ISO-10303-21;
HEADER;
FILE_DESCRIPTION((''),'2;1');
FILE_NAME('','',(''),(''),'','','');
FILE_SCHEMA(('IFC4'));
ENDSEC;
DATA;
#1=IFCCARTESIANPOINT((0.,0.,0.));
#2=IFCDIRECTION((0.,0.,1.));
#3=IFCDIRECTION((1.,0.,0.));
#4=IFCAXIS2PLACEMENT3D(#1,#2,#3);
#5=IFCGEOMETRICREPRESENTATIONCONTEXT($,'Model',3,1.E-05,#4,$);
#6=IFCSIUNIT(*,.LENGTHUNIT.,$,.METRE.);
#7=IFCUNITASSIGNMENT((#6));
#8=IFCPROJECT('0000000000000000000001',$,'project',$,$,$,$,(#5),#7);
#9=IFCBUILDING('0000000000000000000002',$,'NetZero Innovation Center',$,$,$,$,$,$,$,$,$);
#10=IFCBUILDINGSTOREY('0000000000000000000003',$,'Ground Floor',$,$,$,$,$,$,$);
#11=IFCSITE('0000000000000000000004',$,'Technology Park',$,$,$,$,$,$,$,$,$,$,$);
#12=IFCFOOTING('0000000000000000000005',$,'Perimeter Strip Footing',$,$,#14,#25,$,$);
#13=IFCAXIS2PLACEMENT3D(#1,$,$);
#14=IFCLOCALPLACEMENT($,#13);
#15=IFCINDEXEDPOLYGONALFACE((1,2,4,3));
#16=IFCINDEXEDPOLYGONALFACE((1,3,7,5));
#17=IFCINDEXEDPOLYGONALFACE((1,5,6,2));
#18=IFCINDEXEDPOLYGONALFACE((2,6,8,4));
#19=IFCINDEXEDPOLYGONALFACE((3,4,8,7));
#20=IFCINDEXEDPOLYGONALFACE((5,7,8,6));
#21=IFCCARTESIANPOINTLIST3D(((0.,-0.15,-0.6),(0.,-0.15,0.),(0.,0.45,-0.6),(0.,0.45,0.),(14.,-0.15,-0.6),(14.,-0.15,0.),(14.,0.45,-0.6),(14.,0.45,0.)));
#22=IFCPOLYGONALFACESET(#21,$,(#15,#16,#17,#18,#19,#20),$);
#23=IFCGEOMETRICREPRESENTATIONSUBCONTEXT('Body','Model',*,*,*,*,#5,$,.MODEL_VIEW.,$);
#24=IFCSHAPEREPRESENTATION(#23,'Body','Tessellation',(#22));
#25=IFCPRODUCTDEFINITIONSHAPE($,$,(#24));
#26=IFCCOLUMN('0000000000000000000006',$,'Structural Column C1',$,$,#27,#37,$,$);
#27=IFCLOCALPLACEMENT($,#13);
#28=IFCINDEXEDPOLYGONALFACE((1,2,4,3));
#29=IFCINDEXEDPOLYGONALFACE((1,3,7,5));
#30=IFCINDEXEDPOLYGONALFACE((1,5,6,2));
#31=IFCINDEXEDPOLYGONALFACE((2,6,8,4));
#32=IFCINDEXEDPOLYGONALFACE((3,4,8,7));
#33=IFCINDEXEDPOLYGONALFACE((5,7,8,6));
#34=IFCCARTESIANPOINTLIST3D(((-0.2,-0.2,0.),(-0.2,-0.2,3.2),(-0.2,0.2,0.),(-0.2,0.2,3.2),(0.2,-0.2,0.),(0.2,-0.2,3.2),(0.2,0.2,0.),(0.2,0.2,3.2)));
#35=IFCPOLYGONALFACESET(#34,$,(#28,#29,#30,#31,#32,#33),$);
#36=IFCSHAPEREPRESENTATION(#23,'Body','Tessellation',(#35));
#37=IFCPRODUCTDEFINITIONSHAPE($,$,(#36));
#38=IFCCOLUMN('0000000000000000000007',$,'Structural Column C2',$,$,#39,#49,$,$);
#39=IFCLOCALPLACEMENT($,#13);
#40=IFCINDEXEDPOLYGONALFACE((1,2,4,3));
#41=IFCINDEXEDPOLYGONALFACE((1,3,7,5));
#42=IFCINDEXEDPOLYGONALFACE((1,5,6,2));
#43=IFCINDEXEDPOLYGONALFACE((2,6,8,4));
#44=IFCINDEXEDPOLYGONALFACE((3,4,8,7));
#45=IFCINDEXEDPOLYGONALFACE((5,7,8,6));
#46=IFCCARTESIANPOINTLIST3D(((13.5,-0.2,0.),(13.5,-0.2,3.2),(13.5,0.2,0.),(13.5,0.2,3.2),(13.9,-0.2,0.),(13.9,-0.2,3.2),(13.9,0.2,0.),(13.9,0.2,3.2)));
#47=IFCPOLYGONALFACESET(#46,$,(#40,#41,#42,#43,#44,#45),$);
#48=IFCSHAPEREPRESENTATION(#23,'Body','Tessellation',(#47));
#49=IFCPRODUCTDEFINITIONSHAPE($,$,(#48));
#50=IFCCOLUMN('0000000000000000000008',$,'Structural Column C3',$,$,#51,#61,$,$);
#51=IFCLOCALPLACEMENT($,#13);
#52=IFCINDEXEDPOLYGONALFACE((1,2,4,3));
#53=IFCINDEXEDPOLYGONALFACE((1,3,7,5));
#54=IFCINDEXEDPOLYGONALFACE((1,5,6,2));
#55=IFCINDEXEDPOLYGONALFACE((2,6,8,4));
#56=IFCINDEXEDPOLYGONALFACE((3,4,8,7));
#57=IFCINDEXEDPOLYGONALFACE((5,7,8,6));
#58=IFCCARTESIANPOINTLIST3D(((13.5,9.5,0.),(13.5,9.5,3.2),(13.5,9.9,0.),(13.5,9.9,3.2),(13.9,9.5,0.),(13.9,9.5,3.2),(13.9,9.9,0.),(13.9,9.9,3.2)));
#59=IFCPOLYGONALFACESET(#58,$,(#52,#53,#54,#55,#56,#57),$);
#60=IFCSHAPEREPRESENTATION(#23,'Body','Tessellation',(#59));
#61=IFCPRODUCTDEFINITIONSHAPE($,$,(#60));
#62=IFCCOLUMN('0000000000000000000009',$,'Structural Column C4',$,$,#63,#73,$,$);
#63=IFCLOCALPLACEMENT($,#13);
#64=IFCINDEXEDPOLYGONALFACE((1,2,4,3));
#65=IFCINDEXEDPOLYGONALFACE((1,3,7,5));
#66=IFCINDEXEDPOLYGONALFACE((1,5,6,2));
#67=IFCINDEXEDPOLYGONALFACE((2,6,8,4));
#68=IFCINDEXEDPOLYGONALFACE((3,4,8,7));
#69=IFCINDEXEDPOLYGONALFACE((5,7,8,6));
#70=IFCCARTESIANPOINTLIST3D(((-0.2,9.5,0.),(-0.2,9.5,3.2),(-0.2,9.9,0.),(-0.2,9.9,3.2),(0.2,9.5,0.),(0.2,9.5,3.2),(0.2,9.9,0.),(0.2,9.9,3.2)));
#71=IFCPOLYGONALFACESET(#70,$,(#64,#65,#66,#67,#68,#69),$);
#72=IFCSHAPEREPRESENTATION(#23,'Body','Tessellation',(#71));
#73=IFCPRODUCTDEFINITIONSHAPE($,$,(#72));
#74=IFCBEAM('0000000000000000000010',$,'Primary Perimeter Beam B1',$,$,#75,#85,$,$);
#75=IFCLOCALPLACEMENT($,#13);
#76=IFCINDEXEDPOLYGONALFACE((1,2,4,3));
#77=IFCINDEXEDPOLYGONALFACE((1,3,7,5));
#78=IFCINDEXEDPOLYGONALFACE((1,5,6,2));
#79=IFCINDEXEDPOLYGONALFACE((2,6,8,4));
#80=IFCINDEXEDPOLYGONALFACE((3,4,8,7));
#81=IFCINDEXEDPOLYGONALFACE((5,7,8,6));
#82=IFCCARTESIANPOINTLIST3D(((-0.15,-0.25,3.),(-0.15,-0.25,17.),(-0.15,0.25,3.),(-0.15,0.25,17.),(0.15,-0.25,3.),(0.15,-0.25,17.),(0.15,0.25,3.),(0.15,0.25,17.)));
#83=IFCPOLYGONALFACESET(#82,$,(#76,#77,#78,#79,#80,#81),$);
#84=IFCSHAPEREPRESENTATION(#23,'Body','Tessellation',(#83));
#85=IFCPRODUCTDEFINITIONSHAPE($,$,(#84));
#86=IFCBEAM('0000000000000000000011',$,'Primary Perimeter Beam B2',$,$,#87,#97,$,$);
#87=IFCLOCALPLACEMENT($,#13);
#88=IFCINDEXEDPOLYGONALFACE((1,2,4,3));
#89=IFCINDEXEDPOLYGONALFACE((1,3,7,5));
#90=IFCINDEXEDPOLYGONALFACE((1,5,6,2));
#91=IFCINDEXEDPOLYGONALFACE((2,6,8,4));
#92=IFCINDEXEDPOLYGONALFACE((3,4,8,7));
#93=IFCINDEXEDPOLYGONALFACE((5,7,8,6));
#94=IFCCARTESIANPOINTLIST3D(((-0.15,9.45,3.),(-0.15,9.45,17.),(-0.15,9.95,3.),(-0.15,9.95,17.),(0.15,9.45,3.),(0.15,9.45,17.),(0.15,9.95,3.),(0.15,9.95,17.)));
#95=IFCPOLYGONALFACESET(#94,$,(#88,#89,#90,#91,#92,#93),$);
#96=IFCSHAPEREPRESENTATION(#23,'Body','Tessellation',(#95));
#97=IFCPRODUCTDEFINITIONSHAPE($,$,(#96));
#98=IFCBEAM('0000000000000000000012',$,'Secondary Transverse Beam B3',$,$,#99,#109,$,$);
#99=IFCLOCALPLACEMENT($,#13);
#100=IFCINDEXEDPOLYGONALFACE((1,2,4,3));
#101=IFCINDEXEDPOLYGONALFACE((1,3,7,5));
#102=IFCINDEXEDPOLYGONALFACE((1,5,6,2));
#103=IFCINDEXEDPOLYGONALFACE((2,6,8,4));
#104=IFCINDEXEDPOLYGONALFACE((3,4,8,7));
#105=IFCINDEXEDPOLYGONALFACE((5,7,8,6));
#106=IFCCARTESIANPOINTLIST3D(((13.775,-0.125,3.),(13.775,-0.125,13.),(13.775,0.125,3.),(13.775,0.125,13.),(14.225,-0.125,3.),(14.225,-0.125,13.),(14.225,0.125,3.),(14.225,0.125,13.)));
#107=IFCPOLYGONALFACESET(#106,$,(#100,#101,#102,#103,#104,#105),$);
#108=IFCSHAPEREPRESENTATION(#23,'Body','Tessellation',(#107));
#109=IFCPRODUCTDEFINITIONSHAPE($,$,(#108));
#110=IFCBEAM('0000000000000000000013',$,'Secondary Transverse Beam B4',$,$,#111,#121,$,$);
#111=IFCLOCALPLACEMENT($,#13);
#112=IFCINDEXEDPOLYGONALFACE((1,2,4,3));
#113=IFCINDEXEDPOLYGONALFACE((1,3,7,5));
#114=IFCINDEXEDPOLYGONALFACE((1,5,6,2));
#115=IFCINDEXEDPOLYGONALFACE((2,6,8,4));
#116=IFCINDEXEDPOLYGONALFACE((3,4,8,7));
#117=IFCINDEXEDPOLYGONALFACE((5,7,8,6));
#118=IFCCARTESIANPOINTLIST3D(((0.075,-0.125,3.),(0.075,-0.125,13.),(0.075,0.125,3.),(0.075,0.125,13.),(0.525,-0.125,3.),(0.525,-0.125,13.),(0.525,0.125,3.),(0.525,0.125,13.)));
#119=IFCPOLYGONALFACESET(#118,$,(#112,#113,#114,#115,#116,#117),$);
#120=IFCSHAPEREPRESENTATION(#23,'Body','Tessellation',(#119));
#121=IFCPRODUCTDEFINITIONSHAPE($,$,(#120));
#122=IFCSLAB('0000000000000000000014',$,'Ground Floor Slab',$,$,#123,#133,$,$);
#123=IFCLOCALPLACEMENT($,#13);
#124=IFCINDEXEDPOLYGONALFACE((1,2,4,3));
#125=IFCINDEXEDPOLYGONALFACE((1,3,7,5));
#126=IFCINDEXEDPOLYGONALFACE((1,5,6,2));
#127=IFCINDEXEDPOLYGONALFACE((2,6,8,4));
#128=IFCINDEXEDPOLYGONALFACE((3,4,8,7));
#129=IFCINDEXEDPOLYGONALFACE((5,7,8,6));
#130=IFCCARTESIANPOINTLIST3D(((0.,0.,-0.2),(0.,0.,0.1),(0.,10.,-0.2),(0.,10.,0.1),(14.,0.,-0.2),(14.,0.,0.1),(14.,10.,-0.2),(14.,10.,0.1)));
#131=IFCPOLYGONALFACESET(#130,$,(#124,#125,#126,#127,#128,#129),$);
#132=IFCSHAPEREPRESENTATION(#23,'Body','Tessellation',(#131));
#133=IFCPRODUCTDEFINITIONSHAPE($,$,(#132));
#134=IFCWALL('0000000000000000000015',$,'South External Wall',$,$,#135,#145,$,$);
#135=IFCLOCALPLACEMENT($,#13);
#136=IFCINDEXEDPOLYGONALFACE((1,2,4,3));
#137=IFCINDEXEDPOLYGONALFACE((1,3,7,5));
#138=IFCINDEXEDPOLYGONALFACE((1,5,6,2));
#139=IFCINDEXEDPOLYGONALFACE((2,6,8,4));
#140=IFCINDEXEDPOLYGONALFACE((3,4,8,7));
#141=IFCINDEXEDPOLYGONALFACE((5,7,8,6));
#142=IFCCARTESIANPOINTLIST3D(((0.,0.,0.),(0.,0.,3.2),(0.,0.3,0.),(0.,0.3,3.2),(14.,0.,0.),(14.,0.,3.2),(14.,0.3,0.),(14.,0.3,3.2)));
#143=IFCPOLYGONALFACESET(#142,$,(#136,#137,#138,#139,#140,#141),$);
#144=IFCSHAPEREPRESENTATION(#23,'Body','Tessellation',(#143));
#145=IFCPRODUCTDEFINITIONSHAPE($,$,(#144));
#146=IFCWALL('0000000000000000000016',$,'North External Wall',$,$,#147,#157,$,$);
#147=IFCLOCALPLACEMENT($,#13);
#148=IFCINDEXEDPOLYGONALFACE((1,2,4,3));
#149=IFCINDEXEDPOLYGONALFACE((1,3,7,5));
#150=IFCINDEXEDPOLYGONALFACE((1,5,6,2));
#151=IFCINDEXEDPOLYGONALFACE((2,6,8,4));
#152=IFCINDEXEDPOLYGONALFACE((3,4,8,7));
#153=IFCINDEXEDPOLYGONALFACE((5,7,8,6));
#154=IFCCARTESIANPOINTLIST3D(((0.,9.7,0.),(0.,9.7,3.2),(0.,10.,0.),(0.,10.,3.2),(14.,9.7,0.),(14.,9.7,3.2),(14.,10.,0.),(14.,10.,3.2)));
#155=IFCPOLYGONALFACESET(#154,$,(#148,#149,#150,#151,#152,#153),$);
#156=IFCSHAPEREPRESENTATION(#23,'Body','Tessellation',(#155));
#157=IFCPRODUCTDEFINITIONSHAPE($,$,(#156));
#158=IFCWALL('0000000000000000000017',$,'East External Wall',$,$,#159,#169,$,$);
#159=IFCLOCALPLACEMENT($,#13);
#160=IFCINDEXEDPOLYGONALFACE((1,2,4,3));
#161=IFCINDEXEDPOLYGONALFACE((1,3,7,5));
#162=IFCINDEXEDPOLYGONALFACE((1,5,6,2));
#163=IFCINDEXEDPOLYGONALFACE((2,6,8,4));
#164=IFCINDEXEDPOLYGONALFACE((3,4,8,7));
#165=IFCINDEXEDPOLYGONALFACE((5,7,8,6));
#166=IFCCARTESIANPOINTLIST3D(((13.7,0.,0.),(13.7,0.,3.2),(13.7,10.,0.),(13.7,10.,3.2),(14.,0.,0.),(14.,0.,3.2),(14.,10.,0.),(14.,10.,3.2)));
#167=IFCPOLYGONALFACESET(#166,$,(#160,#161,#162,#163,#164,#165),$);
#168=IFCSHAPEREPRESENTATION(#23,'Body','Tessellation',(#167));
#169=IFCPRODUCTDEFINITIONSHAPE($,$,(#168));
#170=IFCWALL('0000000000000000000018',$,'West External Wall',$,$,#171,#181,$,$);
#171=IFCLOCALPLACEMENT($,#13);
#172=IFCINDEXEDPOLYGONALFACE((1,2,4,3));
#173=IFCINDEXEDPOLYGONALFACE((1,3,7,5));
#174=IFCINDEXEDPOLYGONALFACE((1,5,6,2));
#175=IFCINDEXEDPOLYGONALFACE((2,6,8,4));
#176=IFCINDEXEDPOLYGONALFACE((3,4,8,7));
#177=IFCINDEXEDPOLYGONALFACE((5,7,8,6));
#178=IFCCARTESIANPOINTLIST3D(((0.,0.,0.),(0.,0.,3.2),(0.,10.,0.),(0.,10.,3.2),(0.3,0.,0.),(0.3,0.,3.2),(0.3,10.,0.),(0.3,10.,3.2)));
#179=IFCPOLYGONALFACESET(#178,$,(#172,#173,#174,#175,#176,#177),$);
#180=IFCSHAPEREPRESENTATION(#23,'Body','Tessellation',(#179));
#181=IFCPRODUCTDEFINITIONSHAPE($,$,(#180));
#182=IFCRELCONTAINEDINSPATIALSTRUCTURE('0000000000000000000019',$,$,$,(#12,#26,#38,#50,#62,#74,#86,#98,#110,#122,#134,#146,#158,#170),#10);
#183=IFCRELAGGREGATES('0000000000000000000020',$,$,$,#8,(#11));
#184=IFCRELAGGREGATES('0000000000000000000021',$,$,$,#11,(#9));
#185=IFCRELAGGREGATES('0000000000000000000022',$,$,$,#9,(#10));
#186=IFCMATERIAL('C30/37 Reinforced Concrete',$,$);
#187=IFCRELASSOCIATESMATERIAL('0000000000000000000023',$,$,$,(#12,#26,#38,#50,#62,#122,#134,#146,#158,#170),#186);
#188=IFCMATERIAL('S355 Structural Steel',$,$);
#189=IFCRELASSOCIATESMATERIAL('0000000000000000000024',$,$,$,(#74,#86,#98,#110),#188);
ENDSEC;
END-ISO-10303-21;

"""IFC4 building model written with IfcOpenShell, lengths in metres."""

from ifc_helpers import new_model, si_unit, frame, origin_with_axes, origin_2d, place, context, subcontext, project, spatial, indexed_curve, rectangle, outline, extrude, material, element, save


model = new_model("IFC4")

# Units and contexts
model_context = context("Model", 3, precision=1e-05, world=origin_with_axes())
body_context = subcontext(model_context, "Body", "Model", "MODEL_VIEW")
ifc_project = project(units=[si_unit("LENGTHUNIT", "METRE")], contexts=[model_context])

# Site, building, storey
site = spatial("IfcSite", under=ifc_project, Name="Technology Park")
building = spatial("IfcBuilding", under=site, Name="NetZero Innovation Center")
storey = spatial("IfcBuildingStorey", under=building, Name="Ground Floor")

# Footing
ifc_material_1 = material(Name="C30/37 Reinforced Concrete")
footing_placement = place(None, origin_with_axes())
element("IfcFooting", 1, at=footing_placement, inside=storey, material=ifc_material_1, Name="Perimeter Strip Footing", context=body_context, shape_type="SweptSolid", body=[
    extrude(outline(indexed_curve([(0.0, 0.0), (14.0, 0.0), (14.0, 0.6), (0.0, 0.6), (0.0, 0.0)])), frame((0.0, -0.15, -0.6), z_axis=(0.0, 0.0, 1.0), x_axis=(1.0, 0.0, 0.0)), (0.0, 0.0, 1.0), 0.6),
])

# Columns
for number, where, z_axis, x_axis, name in (
    (2, (0.0, 0.0, 0.0), (0.0, 0.0, 1.0), (1.0, 0.0, 0.0), "Structural Column C1"),
    (3, (13.7, 0.0, 0.0), (0.0, 0.0, 1.0), (1.0, 0.0, 0.0), "Structural Column C2"),
    (4, (13.7, 9.7, 0.0), (0.0, 0.0, 1.0), (1.0, 0.0, 0.0), "Structural Column C3"),
    (5, (0.0, 9.7, 0.0), (0.0, 0.0, 1.0), (1.0, 0.0, 0.0), "Structural Column C4"),
):
    element("IfcColumn", number, at=place(None, frame(where, z_axis=z_axis, x_axis=x_axis)), inside=storey, material=ifc_material_1, Name=name, context=body_context, shape_type="SweptSolid", body=[
        extrude(rectangle(XDim=0.4, YDim=0.4, at=origin_2d()), origin_with_axes(), (0.0, 0.0, 1.0), 3.2),
    ])

# Beams
ifc_material_2 = material(Name="S355 Structural Steel")
for number, where, z_axis, x_axis, name in (
    (6, (0.0, 0.0, 3.0), (0.0, 0.0, 1.0), (1.0, 0.0, 0.0), "Primary Perimeter Beam B1"),
    (7, (0.0, 9.7, 3.0), (0.0, 0.0, 1.0), (1.0, 0.0, 0.0), "Primary Perimeter Beam B2"),
):
    element("IfcBeam", number, at=place(None, frame(where, z_axis=z_axis, x_axis=x_axis)), inside=storey, material=ifc_material_2, Name=name, context=body_context, shape_type="SweptSolid", body=[
        extrude(rectangle(XDim=0.3, YDim=0.5, at=origin_2d()), origin_with_axes(), (0.0, 0.0, 1.0), 14.0),
    ])
for number, where, z_axis, x_axis, name in (
    (8, (14.0, 0.0, 3.0), (0.0, 0.0, 1.0), (0.0, 1.0, 0.0), "Secondary Transverse Beam B3"),
    (9, (0.3, 0.0, 3.0), (0.0, 0.0, 1.0), (0.0, 1.0, 0.0), "Secondary Transverse Beam B4"),
):
    element("IfcBeam", number, at=place(None, frame(where, z_axis=z_axis, x_axis=x_axis)), inside=storey, material=ifc_material_2, Name=name, context=body_context, shape_type="SweptSolid", body=[
        extrude(rectangle(XDim=0.25, YDim=0.45, at=origin_2d()), origin_with_axes(), (0.0, 0.0, 1.0), 10.0),
    ])

# Slab
slab_placement = place(None, frame((0.0, 0.0, -0.2), z_axis=(0.0, 0.0, 1.0), x_axis=(1.0, 0.0, 0.0)))
element("IfcSlab", 10, at=slab_placement, inside=storey, material=ifc_material_1, Name="Ground Floor Slab", context=body_context, shape_type="SweptSolid", body=[
    extrude(outline(indexed_curve([(0.0, 0.0), (14.0, 0.0), (14.0, 10.0), (0.0, 10.0), (0.0, 0.0)])), None, (0.0, 0.0, 1.0), 0.3),
])

# Walls
for number, where, z_axis, x_axis, name in (
    (11, (0.0, 0.0, 0.0), (0.0, 0.0, 1.0), (1.0, 0.0, 0.0), "South External Wall"),
    (12, (0.0, 9.7, 0.0), (0.0, 0.0, 1.0), (1.0, 0.0, 0.0), "North External Wall"),
):
    element("IfcWall", number, at=place(None, frame(where, z_axis=z_axis, x_axis=x_axis)), inside=storey, material=ifc_material_1, Name=name, context=body_context, shape_type="SweptSolid", body=[
        extrude(outline(indexed_curve([(0.0, 0.0), (0.0, 0.3), (14.0, 0.3), (14.0, 0.0), (0.0, 0.0)], self_intersect=False)), origin_with_axes(), (0.0, 0.0, 1.0), 3.2),
    ])
for number, where, z_axis, x_axis, name in (
    (13, (14.0, 0.0, 0.0), (0.0, 0.0, 1.0), (0.0, 1.0, 0.0), "East External Wall"),
    (14, (0.3, 0.0, 0.0), (0.0, 0.0, 1.0), (0.0, 1.0, 0.0), "West External Wall"),
):
    element("IfcWall", number, at=place(None, frame(where, z_axis=z_axis, x_axis=x_axis)), inside=storey, material=ifc_material_1, Name=name, context=body_context, shape_type="SweptSolid", body=[
        extrude(outline(indexed_curve([(0.0, 0.0), (0.0, 0.3), (10.0, 0.3), (10.0, 0.0), (0.0, 0.0)], self_intersect=False)), origin_with_axes(), (0.0, 0.0, 1.0), 3.2),
    ])

save(model, "model.ifc")
